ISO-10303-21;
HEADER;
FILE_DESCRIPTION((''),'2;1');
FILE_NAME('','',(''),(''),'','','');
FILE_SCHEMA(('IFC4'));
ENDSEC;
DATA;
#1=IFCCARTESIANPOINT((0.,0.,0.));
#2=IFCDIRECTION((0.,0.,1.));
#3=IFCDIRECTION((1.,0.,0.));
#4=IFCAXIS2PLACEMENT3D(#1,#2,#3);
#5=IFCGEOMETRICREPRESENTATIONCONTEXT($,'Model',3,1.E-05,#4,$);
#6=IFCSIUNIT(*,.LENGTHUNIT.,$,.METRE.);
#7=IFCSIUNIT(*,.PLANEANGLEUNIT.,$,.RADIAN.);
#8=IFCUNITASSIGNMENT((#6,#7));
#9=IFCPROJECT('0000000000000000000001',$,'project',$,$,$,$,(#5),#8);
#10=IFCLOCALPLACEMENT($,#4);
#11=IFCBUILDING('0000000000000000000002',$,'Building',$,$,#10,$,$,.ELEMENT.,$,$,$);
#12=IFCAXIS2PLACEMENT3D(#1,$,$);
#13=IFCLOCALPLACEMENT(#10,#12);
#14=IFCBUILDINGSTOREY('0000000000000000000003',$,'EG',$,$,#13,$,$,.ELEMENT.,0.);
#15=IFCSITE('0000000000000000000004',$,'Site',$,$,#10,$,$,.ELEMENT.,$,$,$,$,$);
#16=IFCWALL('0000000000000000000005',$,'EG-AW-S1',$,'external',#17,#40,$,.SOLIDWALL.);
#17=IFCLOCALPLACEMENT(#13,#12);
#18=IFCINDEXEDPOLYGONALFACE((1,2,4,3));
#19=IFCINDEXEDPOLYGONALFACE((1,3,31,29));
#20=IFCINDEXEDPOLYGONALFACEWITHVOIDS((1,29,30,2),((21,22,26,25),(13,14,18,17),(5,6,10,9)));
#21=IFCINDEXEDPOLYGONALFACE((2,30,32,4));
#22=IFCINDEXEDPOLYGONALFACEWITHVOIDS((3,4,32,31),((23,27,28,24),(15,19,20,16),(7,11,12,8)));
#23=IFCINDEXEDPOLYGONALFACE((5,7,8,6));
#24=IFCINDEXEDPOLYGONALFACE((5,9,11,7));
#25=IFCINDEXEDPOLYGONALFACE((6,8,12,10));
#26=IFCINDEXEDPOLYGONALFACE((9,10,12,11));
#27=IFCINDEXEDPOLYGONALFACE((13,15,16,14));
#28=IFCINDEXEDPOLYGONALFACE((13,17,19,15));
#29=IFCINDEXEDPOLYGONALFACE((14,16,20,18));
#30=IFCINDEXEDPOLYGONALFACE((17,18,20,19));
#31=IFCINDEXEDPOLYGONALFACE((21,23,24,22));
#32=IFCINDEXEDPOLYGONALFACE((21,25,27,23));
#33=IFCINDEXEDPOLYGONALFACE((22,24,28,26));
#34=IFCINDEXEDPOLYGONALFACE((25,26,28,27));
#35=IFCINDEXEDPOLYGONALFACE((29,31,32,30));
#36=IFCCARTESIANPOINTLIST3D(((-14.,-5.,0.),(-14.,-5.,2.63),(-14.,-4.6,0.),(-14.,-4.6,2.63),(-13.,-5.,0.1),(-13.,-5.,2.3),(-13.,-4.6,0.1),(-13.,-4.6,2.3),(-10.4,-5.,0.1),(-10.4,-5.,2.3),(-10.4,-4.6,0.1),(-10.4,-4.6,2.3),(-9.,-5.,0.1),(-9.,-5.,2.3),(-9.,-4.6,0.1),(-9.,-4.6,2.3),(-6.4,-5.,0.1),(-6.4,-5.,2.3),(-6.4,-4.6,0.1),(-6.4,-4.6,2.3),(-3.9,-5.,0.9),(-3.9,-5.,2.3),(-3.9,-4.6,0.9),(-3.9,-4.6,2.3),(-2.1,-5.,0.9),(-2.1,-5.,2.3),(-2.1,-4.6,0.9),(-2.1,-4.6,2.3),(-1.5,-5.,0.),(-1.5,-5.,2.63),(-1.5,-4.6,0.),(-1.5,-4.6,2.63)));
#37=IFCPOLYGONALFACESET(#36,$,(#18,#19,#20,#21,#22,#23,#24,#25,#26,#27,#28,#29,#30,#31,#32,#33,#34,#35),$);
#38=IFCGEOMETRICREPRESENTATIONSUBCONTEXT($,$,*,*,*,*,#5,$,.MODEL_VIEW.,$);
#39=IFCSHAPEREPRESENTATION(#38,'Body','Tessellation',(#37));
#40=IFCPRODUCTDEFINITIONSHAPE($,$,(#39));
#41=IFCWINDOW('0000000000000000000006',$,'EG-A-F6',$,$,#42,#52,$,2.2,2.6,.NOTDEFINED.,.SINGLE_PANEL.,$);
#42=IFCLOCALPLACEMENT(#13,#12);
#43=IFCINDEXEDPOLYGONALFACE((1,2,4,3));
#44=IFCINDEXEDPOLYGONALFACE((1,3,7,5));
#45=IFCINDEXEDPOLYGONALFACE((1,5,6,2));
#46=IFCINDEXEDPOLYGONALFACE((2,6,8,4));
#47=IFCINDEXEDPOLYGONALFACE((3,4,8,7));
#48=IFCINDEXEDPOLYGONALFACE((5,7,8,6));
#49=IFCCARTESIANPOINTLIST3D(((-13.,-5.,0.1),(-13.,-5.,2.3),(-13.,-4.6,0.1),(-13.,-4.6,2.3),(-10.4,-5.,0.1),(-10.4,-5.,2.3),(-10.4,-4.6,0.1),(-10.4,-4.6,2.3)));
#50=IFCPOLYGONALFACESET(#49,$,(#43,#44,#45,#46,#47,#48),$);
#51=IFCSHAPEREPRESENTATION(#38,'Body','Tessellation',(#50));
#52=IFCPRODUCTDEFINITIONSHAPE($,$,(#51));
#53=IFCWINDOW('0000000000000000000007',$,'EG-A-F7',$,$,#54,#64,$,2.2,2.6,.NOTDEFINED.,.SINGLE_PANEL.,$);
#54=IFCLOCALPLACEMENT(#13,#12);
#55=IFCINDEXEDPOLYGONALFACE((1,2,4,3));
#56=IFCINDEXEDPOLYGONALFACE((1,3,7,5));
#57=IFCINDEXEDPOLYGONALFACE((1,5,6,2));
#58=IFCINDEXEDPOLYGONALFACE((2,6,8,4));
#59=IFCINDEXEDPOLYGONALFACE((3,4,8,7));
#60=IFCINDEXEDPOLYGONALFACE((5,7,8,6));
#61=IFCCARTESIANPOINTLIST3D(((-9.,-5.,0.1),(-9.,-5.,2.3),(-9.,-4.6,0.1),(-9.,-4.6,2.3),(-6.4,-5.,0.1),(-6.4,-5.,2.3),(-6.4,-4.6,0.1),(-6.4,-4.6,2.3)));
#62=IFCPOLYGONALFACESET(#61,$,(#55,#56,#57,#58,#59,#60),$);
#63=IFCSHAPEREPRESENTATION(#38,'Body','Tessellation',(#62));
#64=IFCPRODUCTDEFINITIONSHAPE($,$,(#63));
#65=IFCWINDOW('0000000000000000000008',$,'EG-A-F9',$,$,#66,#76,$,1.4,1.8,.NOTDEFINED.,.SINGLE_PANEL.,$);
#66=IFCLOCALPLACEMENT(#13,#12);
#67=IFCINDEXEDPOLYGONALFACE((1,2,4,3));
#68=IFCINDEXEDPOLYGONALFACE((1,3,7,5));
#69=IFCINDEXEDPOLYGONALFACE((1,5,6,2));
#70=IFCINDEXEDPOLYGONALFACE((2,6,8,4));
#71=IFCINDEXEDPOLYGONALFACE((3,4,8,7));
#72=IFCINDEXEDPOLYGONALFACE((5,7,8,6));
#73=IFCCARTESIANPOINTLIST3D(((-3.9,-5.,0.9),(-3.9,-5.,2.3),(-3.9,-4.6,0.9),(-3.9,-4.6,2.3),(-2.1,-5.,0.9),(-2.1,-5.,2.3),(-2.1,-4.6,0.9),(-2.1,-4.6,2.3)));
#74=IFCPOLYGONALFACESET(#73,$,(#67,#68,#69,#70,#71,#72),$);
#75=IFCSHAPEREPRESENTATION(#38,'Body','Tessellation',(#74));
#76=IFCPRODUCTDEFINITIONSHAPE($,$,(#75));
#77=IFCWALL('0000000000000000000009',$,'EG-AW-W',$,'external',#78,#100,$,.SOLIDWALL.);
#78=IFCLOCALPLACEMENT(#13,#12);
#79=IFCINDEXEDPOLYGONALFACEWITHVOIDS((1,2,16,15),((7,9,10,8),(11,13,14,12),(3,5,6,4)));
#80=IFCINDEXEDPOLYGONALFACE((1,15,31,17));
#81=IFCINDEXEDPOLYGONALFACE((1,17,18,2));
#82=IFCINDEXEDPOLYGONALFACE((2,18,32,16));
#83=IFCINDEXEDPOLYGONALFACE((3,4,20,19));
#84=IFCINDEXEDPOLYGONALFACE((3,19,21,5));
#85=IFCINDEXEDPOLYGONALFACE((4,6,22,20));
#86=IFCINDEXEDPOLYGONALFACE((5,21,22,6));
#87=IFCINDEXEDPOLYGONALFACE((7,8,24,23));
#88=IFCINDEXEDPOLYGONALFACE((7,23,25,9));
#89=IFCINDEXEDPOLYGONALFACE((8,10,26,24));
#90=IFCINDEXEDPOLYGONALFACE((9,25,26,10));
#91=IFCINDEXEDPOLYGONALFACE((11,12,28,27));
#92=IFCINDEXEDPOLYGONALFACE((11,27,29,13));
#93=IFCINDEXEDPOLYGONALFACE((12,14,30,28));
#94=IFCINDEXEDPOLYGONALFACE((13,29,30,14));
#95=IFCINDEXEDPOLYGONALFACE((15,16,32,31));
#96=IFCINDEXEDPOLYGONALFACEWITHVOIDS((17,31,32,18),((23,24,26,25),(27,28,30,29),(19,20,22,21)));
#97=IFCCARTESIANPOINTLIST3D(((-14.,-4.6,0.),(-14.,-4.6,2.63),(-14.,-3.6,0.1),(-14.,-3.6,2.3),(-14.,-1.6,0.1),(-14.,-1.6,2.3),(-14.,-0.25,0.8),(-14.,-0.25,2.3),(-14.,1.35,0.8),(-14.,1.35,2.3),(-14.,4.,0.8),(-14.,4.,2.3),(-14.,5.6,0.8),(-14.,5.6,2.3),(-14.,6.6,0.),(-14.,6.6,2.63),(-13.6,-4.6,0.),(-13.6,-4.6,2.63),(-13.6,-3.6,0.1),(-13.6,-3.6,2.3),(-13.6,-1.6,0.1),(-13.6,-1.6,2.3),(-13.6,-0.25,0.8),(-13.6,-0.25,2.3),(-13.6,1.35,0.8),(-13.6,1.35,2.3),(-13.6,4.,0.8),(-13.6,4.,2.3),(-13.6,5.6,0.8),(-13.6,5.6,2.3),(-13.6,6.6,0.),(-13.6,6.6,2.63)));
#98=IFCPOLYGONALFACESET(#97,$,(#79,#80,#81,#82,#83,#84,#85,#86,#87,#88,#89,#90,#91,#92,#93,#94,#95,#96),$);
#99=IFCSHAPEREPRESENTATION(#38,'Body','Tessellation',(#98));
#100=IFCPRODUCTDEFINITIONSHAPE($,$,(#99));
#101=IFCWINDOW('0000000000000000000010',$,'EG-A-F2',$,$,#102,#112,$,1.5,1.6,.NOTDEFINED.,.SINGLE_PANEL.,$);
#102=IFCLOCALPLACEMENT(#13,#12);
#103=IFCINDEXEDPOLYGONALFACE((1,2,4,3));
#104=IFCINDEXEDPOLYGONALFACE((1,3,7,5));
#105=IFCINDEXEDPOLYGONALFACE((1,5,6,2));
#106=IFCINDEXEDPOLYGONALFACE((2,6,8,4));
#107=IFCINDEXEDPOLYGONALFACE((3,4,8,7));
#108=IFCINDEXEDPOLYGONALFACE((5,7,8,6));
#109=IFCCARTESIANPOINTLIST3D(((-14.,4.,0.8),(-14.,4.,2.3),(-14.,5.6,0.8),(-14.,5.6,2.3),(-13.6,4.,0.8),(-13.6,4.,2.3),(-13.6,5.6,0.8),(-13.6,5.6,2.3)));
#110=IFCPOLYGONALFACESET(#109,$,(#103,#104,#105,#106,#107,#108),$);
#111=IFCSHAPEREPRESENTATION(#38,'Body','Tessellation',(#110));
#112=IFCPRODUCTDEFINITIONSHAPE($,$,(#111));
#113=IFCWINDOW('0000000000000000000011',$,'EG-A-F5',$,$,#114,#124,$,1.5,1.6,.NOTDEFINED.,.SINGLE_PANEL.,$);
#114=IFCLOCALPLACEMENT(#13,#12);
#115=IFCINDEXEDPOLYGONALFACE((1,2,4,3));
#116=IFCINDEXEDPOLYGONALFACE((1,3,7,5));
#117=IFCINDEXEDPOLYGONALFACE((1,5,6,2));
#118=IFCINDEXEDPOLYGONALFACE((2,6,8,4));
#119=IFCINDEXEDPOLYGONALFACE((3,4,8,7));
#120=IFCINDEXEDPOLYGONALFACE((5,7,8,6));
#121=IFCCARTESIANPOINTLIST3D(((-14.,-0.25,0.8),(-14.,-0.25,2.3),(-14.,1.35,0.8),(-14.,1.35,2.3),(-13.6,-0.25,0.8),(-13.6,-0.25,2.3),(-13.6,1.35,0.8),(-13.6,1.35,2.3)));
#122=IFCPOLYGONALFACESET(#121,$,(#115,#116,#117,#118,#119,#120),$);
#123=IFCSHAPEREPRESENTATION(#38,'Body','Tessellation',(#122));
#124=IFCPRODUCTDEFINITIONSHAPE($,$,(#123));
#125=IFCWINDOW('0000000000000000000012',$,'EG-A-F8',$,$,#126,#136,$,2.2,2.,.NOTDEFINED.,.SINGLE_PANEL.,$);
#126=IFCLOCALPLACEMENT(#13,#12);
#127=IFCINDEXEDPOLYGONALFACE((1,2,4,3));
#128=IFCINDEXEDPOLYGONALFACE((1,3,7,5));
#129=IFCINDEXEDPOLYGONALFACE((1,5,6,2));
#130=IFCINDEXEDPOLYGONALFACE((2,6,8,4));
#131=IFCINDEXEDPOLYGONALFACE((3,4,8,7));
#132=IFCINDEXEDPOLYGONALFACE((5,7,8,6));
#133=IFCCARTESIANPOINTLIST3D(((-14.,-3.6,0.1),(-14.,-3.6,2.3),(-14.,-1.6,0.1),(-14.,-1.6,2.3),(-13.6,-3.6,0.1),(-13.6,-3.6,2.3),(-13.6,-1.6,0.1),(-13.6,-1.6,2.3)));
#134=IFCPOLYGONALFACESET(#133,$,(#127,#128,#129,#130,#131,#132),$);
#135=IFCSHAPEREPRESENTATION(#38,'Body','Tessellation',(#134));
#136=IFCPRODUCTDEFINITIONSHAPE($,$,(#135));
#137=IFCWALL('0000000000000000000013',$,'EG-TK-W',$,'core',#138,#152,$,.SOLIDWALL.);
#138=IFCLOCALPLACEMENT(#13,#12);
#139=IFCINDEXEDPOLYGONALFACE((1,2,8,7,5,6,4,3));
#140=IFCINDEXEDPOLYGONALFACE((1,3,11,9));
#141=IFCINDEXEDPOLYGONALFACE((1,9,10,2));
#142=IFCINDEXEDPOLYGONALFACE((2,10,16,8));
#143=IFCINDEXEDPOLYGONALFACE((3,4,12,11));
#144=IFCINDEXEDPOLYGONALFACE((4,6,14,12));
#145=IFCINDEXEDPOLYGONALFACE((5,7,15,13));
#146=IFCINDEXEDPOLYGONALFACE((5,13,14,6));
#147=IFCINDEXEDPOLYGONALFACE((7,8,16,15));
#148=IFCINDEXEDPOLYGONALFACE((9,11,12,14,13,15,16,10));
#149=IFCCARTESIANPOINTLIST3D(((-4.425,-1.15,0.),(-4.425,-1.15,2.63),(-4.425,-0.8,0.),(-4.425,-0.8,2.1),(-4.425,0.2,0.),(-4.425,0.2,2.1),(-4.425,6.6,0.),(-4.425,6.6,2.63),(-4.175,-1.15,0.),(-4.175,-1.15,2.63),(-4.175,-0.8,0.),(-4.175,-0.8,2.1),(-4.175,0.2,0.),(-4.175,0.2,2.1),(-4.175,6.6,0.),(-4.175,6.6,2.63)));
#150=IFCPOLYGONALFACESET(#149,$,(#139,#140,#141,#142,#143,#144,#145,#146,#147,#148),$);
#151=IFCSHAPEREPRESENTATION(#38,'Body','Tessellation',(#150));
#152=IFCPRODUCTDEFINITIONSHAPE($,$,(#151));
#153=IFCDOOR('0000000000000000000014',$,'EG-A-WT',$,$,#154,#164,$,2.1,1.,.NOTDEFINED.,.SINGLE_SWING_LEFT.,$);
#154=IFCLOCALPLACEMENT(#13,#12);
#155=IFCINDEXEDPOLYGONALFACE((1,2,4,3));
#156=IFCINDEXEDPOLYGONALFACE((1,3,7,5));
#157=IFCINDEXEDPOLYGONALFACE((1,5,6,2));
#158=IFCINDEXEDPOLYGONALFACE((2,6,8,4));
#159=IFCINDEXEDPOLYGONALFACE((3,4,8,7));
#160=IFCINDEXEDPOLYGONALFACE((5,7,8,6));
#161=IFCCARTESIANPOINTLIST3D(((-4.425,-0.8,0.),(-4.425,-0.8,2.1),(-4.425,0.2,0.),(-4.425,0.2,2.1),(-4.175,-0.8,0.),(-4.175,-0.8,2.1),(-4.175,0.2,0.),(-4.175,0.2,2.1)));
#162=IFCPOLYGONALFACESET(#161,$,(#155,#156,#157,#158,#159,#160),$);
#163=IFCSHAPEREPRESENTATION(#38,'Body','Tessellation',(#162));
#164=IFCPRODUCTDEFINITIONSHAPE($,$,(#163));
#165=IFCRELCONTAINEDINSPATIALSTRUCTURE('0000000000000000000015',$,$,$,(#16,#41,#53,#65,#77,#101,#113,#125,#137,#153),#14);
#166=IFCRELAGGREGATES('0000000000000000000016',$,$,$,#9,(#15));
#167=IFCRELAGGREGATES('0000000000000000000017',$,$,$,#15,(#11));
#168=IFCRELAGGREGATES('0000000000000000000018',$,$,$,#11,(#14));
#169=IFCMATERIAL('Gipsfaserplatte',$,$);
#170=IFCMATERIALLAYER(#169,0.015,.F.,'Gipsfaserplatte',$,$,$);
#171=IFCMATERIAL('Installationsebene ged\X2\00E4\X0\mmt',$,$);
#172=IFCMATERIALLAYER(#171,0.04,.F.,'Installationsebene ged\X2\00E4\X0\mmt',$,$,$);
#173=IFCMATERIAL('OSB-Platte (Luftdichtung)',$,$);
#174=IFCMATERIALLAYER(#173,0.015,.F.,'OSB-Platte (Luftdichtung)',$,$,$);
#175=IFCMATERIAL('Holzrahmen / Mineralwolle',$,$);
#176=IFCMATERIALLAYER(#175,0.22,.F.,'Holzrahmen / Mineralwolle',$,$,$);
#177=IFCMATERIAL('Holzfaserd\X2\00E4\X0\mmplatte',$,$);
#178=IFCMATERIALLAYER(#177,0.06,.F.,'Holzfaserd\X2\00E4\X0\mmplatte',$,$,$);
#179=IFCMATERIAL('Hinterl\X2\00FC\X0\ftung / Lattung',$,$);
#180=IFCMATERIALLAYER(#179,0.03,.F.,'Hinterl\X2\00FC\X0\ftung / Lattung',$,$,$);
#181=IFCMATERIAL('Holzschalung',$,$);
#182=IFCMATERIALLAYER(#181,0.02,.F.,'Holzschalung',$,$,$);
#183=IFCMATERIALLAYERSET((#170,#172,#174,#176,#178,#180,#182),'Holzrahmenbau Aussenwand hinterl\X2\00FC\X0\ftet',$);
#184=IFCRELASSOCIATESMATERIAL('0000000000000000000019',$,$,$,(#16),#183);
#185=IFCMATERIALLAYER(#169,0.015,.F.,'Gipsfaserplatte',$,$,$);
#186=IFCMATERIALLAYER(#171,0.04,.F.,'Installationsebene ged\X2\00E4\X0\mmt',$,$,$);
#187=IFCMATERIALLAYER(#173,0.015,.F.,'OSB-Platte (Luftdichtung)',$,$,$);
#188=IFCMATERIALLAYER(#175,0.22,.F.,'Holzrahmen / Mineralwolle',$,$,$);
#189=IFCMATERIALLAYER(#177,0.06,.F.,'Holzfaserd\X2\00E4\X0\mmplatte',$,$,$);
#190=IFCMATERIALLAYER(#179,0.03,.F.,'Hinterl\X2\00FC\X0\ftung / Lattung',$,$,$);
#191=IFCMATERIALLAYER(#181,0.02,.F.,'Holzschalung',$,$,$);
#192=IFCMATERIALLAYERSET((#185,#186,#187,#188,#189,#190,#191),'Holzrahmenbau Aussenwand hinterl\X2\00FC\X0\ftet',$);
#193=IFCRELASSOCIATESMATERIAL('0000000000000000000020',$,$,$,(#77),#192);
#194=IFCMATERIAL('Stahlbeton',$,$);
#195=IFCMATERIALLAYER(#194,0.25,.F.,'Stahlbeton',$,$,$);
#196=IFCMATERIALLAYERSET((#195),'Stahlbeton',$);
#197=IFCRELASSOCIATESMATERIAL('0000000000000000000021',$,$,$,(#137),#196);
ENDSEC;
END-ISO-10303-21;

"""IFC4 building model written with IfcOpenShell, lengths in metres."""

from ifc_helpers import new_model, si_unit, frame, frame_2d, origin, origin_with_axes, place, context, subcontext, project, spatial, rectangle, extrude, material, layer, layer_set, element, fill, save


model = new_model("IFC4")

# Units and contexts
model_context = context("Model", 3, precision=1e-05, world=origin_with_axes())
sub_context = subcontext(model_context, None, None, "MODEL_VIEW")
ifc_project = project(units=[si_unit("LENGTHUNIT", "METRE"), si_unit("PLANEANGLEUNIT", "RADIAN")], contexts=[model_context])

# Site, building, storey
placement = place(None, origin_with_axes())
site = spatial("IfcSite", under=ifc_project, at=placement, Name="Site", CompositionType="ELEMENT")
building = spatial("IfcBuilding", under=site, at=placement, Name="Building", CompositionType="ELEMENT")
storey_placement = place(placement, origin())
storey = spatial("IfcBuildingStorey", under=building, at=storey_placement, Name="EG", CompositionType="ELEMENT", Elevation=0.0)

# Walls, openings, windows
ifc_material_1 = material(Name="Gipsfaserplatte")
ifc_layer_1 = layer(ifc_material_1, 0.015, ventilated=False, Name="Gipsfaserplatte")
ifc_material_2 = material(Name="Installationsebene gedämmt")
ifc_layer_2 = layer(ifc_material_2, 0.04, ventilated=False, Name="Installationsebene gedämmt")
ifc_material_3 = material(Name="OSB-Platte (Luftdichtung)")
ifc_layer_3 = layer(ifc_material_3, 0.015, ventilated=False, Name="OSB-Platte (Luftdichtung)")
ifc_material_4 = material(Name="Holzrahmen / Mineralwolle")
ifc_layer_4 = layer(ifc_material_4, 0.22, ventilated=False, Name="Holzrahmen / Mineralwolle")
ifc_material_5 = material(Name="Holzfaserdämmplatte")
ifc_layer_5 = layer(ifc_material_5, 0.06, ventilated=False, Name="Holzfaserdämmplatte")
ifc_material_6 = material(Name="Hinterlüftung / Lattung")
ifc_layer_6 = layer(ifc_material_6, 0.03, ventilated=False, Name="Hinterlüftung / Lattung")
ifc_material_7 = material(Name="Holzschalung")
ifc_layer_7 = layer(ifc_material_7, 0.02, ventilated=False, Name="Holzschalung")
ifc_layer_set_1 = layer_set([ifc_layer_1, ifc_layer_2, ifc_layer_3, ifc_layer_4, ifc_layer_5, ifc_layer_6, ifc_layer_7], Name="Holzrahmenbau Aussenwand hinterlüftet")
wall_1_placement = place(storey_placement, frame((-14.0, -4.8, 0.0), z_axis=(0.0, 0.0, 1.0), x_axis=(1.0, 0.0, 0.0)))
wall_1 = element("IfcWall", 1, at=wall_1_placement, inside=storey, material=ifc_layer_set_1, Name="EG-AW-S1", ObjectType="external", PredefinedType="SOLIDWALL", context=sub_context, shape_type="SweptSolid", body=[
    extrude(rectangle(XDim=12.5, YDim=0.4, at=frame_2d((6.25, 0.0))), origin(), (0.0, 0.0, 1.0), 2.63),
])
opening_1_placement = place(wall_1_placement, frame((2.3, 0.25, 0.1), z_axis=(0.0, -1.0, 0.0), x_axis=(1.0, 0.0, 0.0)))
opening_1 = element("IfcOpeningElement", 2, at=opening_1_placement, cuts=wall_1, PredefinedType="OPENING", context=sub_context, shape_type="SweptSolid", body=[
    extrude(rectangle(XDim=2.6, YDim=2.2, at=frame_2d((0.0, 1.1))), origin(), (0.0, 0.0, 1.0), 0.5),
])
opening_2_placement = place(wall_1_placement, frame((6.3, 0.25, 0.1), z_axis=(0.0, -1.0, 0.0), x_axis=(1.0, 0.0, 0.0)))
opening_2 = element("IfcOpeningElement", 3, at=opening_2_placement, cuts=wall_1, PredefinedType="OPENING", context=sub_context, shape_type="SweptSolid", body=[
    extrude(rectangle(XDim=2.6, YDim=2.2, at=frame_2d((0.0, 1.1))), origin(), (0.0, 0.0, 1.0), 0.5),
])
opening_3_placement = place(wall_1_placement, frame((11.0, 0.25, 0.9), z_axis=(0.0, -1.0, 0.0), x_axis=(1.0, 0.0, 0.0)))
opening_3 = element("IfcOpeningElement", 4, at=opening_3_placement, cuts=wall_1, PredefinedType="OPENING", context=sub_context, shape_type="SweptSolid", body=[
    extrude(rectangle(XDim=1.8, YDim=1.4, at=frame_2d((0.0, 0.7))), origin(), (0.0, 0.0, 1.0), 0.5),
])
window_1_placement = place(wall_1_placement, frame((2.3, 0.2, 0.1), z_axis=(0.0, -1.0, 0.0), x_axis=(1.0, 0.0, 0.0)))
window_1 = element("IfcWindow", 5, at=window_1_placement, inside=storey, Name="EG-A-F6", OverallHeight=2.2, OverallWidth=2.6, PartitioningType="SINGLE_PANEL", PredefinedType="NOTDEFINED", context=sub_context, shape_type="SweptSolid", body=[
    extrude(rectangle(XDim=2.6, YDim=2.2, at=frame_2d((0.0, 1.1))), origin(), (0.0, 0.0, 1.0), 0.4),
])
fill(opening_1, window_1)
window_2_placement = place(wall_1_placement, frame((6.3, 0.2, 0.1), z_axis=(0.0, -1.0, 0.0), x_axis=(1.0, 0.0, 0.0)))
window_2 = element("IfcWindow", 6, at=window_2_placement, inside=storey, Name="EG-A-F7", OverallHeight=2.2, OverallWidth=2.6, PartitioningType="SINGLE_PANEL", PredefinedType="NOTDEFINED", context=sub_context, shape_type="SweptSolid", body=[
    extrude(rectangle(XDim=2.6, YDim=2.2, at=frame_2d((0.0, 1.1))), origin(), (0.0, 0.0, 1.0), 0.4),
])
fill(opening_2, window_2)
window_3_placement = place(wall_1_placement, frame((11.0, 0.2, 0.9), z_axis=(0.0, -1.0, 0.0), x_axis=(1.0, 0.0, 0.0)))
window_3 = element("IfcWindow", 7, at=window_3_placement, inside=storey, Name="EG-A-F9", OverallHeight=1.4, OverallWidth=1.8, PartitioningType="SINGLE_PANEL", PredefinedType="NOTDEFINED", context=sub_context, shape_type="SweptSolid", body=[
    extrude(rectangle(XDim=1.8, YDim=1.4, at=frame_2d((0.0, 0.7))), origin(), (0.0, 0.0, 1.0), 0.4),
])
fill(opening_3, window_3)
ifc_layer_8 = layer(ifc_material_1, 0.015, ventilated=False, Name="Gipsfaserplatte")
ifc_layer_9 = layer(ifc_material_2, 0.04, ventilated=False, Name="Installationsebene gedämmt")
ifc_layer_10 = layer(ifc_material_3, 0.015, ventilated=False, Name="OSB-Platte (Luftdichtung)")
ifc_layer_11 = layer(ifc_material_4, 0.22, ventilated=False, Name="Holzrahmen / Mineralwolle")
ifc_layer_12 = layer(ifc_material_5, 0.06, ventilated=False, Name="Holzfaserdämmplatte")
ifc_layer_13 = layer(ifc_material_6, 0.03, ventilated=False, Name="Hinterlüftung / Lattung")
ifc_layer_14 = layer(ifc_material_7, 0.02, ventilated=False, Name="Holzschalung")
ifc_layer_set_2 = layer_set([ifc_layer_8, ifc_layer_9, ifc_layer_10, ifc_layer_11, ifc_layer_12, ifc_layer_13, ifc_layer_14], Name="Holzrahmenbau Aussenwand hinterlüftet")
wall_2_placement = place(storey_placement, frame((-13.8, -4.6, 0.0), z_axis=(0.0, 0.0, 1.0), x_axis=(0.0, 1.0, 0.0)))
wall_2 = element("IfcWall", 8, at=wall_2_placement, inside=storey, material=ifc_layer_set_2, Name="EG-AW-W", ObjectType="external", PredefinedType="SOLIDWALL", context=sub_context, shape_type="SweptSolid", body=[
    extrude(rectangle(XDim=11.2, YDim=0.4, at=frame_2d((5.6, 0.0))), origin(), (0.0, 0.0, 1.0), 2.63),
])
opening_4_placement = place(wall_2_placement, frame((9.4, 0.25, 0.8), z_axis=(0.0, -1.0, 0.0), x_axis=(1.0, 0.0, 0.0)))
opening_4 = element("IfcOpeningElement", 9, at=opening_4_placement, cuts=wall_2, PredefinedType="OPENING", context=sub_context, shape_type="SweptSolid", body=[
    extrude(rectangle(XDim=1.6, YDim=1.5, at=frame_2d((0.0, 0.75))), origin(), (0.0, 0.0, 1.0), 0.5),
])
opening_5_placement = place(wall_2_placement, frame((5.15, 0.25, 0.8), z_axis=(0.0, -1.0, 0.0), x_axis=(1.0, 0.0, 0.0)))
opening_5 = element("IfcOpeningElement", 10, at=opening_5_placement, cuts=wall_2, PredefinedType="OPENING", context=sub_context, shape_type="SweptSolid", body=[
    extrude(rectangle(XDim=1.6, YDim=1.5, at=frame_2d((0.0, 0.75))), origin(), (0.0, 0.0, 1.0), 0.5),
])
opening_6_placement = place(wall_2_placement, frame((2.0, 0.25, 0.1), z_axis=(0.0, -1.0, 0.0), x_axis=(1.0, 0.0, 0.0)))
opening_6 = element("IfcOpeningElement", 11, at=opening_6_placement, cuts=wall_2, PredefinedType="OPENING", context=sub_context, shape_type="SweptSolid", body=[
    extrude(rectangle(XDim=2.0, YDim=2.2, at=frame_2d((0.0, 1.1))), origin(), (0.0, 0.0, 1.0), 0.5),
])
window_4_placement = place(wall_2_placement, frame((9.4, 0.2, 0.8), z_axis=(0.0, -1.0, 0.0), x_axis=(1.0, 0.0, 0.0)))
window_4 = element("IfcWindow", 12, at=window_4_placement, inside=storey, Name="EG-A-F2", OverallHeight=1.5, OverallWidth=1.6, PartitioningType="SINGLE_PANEL", PredefinedType="NOTDEFINED", context=sub_context, shape_type="SweptSolid", body=[
    extrude(rectangle(XDim=1.6, YDim=1.5, at=frame_2d((0.0, 0.75))), origin(), (0.0, 0.0, 1.0), 0.4),
])
fill(opening_4, window_4)
window_5_placement = place(wall_2_placement, frame((5.15, 0.2, 0.8), z_axis=(0.0, -1.0, 0.0), x_axis=(1.0, 0.0, 0.0)))
window_5 = element("IfcWindow", 13, at=window_5_placement, inside=storey, Name="EG-A-F5", OverallHeight=1.5, OverallWidth=1.6, PartitioningType="SINGLE_PANEL", PredefinedType="NOTDEFINED", context=sub_context, shape_type="SweptSolid", body=[
    extrude(rectangle(XDim=1.6, YDim=1.5, at=frame_2d((0.0, 0.75))), origin(), (0.0, 0.0, 1.0), 0.4),
])
fill(opening_5, window_5)
window_6_placement = place(wall_2_placement, frame((2.0, 0.2, 0.1), z_axis=(0.0, -1.0, 0.0), x_axis=(1.0, 0.0, 0.0)))
window_6 = element("IfcWindow", 14, at=window_6_placement, inside=storey, Name="EG-A-F8", OverallHeight=2.2, OverallWidth=2.0, PartitioningType="SINGLE_PANEL", PredefinedType="NOTDEFINED", context=sub_context, shape_type="SweptSolid", body=[
    extrude(rectangle(XDim=2.0, YDim=2.2, at=frame_2d((0.0, 1.1))), origin(), (0.0, 0.0, 1.0), 0.4),
])
fill(opening_6, window_6)

# Wall, opening, door
ifc_material_8 = material(Name="Stahlbeton")
ifc_layer_15 = layer(ifc_material_8, 0.25, ventilated=False, Name="Stahlbeton")
ifc_layer_set_3 = layer_set([ifc_layer_15], Name="Stahlbeton")
wall_3_placement = place(storey_placement, frame((-4.3, -1.15, 0.0), z_axis=(0.0, 0.0, 1.0), x_axis=(0.0, 1.0, 0.0)))
wall_3 = element("IfcWall", 15, at=wall_3_placement, inside=storey, material=ifc_layer_set_3, Name="EG-TK-W", ObjectType="core", PredefinedType="SOLIDWALL", context=sub_context, shape_type="SweptSolid", body=[
    extrude(rectangle(XDim=7.75, YDim=0.25, at=frame_2d((3.875, 0.0))), origin(), (0.0, 0.0, 1.0), 2.63),
])
opening_7_placement = place(wall_3_placement, frame((0.85, 0.175, 0.0), z_axis=(0.0, -1.0, 0.0), x_axis=(1.0, 0.0, 0.0)))
opening_7 = element("IfcOpeningElement", 16, at=opening_7_placement, cuts=wall_3, PredefinedType="OPENING", context=sub_context, shape_type="SweptSolid", body=[
    extrude(rectangle(XDim=1.0, YDim=2.1, at=frame_2d((0.0, 1.05))), origin(), (0.0, 0.0, 1.0), 0.35),
])
door_1_placement = place(wall_3_placement, frame((0.85, 0.125, 0.0), z_axis=(0.0, -1.0, 0.0), x_axis=(1.0, 0.0, 0.0)))
door_1 = element("IfcDoor", 17, at=door_1_placement, inside=storey, Name="EG-A-WT", OperationType="SINGLE_SWING_LEFT", OverallHeight=2.1, OverallWidth=1.0, PredefinedType="NOTDEFINED", context=sub_context, shape_type="SweptSolid", body=[
    extrude(rectangle(XDim=1.0, YDim=2.1, at=frame_2d((0.0, 1.05))), origin(), (0.0, 0.0, 1.0), 0.25),
])
fill(opening_7, door_1)

save(model, "model.ifc")
